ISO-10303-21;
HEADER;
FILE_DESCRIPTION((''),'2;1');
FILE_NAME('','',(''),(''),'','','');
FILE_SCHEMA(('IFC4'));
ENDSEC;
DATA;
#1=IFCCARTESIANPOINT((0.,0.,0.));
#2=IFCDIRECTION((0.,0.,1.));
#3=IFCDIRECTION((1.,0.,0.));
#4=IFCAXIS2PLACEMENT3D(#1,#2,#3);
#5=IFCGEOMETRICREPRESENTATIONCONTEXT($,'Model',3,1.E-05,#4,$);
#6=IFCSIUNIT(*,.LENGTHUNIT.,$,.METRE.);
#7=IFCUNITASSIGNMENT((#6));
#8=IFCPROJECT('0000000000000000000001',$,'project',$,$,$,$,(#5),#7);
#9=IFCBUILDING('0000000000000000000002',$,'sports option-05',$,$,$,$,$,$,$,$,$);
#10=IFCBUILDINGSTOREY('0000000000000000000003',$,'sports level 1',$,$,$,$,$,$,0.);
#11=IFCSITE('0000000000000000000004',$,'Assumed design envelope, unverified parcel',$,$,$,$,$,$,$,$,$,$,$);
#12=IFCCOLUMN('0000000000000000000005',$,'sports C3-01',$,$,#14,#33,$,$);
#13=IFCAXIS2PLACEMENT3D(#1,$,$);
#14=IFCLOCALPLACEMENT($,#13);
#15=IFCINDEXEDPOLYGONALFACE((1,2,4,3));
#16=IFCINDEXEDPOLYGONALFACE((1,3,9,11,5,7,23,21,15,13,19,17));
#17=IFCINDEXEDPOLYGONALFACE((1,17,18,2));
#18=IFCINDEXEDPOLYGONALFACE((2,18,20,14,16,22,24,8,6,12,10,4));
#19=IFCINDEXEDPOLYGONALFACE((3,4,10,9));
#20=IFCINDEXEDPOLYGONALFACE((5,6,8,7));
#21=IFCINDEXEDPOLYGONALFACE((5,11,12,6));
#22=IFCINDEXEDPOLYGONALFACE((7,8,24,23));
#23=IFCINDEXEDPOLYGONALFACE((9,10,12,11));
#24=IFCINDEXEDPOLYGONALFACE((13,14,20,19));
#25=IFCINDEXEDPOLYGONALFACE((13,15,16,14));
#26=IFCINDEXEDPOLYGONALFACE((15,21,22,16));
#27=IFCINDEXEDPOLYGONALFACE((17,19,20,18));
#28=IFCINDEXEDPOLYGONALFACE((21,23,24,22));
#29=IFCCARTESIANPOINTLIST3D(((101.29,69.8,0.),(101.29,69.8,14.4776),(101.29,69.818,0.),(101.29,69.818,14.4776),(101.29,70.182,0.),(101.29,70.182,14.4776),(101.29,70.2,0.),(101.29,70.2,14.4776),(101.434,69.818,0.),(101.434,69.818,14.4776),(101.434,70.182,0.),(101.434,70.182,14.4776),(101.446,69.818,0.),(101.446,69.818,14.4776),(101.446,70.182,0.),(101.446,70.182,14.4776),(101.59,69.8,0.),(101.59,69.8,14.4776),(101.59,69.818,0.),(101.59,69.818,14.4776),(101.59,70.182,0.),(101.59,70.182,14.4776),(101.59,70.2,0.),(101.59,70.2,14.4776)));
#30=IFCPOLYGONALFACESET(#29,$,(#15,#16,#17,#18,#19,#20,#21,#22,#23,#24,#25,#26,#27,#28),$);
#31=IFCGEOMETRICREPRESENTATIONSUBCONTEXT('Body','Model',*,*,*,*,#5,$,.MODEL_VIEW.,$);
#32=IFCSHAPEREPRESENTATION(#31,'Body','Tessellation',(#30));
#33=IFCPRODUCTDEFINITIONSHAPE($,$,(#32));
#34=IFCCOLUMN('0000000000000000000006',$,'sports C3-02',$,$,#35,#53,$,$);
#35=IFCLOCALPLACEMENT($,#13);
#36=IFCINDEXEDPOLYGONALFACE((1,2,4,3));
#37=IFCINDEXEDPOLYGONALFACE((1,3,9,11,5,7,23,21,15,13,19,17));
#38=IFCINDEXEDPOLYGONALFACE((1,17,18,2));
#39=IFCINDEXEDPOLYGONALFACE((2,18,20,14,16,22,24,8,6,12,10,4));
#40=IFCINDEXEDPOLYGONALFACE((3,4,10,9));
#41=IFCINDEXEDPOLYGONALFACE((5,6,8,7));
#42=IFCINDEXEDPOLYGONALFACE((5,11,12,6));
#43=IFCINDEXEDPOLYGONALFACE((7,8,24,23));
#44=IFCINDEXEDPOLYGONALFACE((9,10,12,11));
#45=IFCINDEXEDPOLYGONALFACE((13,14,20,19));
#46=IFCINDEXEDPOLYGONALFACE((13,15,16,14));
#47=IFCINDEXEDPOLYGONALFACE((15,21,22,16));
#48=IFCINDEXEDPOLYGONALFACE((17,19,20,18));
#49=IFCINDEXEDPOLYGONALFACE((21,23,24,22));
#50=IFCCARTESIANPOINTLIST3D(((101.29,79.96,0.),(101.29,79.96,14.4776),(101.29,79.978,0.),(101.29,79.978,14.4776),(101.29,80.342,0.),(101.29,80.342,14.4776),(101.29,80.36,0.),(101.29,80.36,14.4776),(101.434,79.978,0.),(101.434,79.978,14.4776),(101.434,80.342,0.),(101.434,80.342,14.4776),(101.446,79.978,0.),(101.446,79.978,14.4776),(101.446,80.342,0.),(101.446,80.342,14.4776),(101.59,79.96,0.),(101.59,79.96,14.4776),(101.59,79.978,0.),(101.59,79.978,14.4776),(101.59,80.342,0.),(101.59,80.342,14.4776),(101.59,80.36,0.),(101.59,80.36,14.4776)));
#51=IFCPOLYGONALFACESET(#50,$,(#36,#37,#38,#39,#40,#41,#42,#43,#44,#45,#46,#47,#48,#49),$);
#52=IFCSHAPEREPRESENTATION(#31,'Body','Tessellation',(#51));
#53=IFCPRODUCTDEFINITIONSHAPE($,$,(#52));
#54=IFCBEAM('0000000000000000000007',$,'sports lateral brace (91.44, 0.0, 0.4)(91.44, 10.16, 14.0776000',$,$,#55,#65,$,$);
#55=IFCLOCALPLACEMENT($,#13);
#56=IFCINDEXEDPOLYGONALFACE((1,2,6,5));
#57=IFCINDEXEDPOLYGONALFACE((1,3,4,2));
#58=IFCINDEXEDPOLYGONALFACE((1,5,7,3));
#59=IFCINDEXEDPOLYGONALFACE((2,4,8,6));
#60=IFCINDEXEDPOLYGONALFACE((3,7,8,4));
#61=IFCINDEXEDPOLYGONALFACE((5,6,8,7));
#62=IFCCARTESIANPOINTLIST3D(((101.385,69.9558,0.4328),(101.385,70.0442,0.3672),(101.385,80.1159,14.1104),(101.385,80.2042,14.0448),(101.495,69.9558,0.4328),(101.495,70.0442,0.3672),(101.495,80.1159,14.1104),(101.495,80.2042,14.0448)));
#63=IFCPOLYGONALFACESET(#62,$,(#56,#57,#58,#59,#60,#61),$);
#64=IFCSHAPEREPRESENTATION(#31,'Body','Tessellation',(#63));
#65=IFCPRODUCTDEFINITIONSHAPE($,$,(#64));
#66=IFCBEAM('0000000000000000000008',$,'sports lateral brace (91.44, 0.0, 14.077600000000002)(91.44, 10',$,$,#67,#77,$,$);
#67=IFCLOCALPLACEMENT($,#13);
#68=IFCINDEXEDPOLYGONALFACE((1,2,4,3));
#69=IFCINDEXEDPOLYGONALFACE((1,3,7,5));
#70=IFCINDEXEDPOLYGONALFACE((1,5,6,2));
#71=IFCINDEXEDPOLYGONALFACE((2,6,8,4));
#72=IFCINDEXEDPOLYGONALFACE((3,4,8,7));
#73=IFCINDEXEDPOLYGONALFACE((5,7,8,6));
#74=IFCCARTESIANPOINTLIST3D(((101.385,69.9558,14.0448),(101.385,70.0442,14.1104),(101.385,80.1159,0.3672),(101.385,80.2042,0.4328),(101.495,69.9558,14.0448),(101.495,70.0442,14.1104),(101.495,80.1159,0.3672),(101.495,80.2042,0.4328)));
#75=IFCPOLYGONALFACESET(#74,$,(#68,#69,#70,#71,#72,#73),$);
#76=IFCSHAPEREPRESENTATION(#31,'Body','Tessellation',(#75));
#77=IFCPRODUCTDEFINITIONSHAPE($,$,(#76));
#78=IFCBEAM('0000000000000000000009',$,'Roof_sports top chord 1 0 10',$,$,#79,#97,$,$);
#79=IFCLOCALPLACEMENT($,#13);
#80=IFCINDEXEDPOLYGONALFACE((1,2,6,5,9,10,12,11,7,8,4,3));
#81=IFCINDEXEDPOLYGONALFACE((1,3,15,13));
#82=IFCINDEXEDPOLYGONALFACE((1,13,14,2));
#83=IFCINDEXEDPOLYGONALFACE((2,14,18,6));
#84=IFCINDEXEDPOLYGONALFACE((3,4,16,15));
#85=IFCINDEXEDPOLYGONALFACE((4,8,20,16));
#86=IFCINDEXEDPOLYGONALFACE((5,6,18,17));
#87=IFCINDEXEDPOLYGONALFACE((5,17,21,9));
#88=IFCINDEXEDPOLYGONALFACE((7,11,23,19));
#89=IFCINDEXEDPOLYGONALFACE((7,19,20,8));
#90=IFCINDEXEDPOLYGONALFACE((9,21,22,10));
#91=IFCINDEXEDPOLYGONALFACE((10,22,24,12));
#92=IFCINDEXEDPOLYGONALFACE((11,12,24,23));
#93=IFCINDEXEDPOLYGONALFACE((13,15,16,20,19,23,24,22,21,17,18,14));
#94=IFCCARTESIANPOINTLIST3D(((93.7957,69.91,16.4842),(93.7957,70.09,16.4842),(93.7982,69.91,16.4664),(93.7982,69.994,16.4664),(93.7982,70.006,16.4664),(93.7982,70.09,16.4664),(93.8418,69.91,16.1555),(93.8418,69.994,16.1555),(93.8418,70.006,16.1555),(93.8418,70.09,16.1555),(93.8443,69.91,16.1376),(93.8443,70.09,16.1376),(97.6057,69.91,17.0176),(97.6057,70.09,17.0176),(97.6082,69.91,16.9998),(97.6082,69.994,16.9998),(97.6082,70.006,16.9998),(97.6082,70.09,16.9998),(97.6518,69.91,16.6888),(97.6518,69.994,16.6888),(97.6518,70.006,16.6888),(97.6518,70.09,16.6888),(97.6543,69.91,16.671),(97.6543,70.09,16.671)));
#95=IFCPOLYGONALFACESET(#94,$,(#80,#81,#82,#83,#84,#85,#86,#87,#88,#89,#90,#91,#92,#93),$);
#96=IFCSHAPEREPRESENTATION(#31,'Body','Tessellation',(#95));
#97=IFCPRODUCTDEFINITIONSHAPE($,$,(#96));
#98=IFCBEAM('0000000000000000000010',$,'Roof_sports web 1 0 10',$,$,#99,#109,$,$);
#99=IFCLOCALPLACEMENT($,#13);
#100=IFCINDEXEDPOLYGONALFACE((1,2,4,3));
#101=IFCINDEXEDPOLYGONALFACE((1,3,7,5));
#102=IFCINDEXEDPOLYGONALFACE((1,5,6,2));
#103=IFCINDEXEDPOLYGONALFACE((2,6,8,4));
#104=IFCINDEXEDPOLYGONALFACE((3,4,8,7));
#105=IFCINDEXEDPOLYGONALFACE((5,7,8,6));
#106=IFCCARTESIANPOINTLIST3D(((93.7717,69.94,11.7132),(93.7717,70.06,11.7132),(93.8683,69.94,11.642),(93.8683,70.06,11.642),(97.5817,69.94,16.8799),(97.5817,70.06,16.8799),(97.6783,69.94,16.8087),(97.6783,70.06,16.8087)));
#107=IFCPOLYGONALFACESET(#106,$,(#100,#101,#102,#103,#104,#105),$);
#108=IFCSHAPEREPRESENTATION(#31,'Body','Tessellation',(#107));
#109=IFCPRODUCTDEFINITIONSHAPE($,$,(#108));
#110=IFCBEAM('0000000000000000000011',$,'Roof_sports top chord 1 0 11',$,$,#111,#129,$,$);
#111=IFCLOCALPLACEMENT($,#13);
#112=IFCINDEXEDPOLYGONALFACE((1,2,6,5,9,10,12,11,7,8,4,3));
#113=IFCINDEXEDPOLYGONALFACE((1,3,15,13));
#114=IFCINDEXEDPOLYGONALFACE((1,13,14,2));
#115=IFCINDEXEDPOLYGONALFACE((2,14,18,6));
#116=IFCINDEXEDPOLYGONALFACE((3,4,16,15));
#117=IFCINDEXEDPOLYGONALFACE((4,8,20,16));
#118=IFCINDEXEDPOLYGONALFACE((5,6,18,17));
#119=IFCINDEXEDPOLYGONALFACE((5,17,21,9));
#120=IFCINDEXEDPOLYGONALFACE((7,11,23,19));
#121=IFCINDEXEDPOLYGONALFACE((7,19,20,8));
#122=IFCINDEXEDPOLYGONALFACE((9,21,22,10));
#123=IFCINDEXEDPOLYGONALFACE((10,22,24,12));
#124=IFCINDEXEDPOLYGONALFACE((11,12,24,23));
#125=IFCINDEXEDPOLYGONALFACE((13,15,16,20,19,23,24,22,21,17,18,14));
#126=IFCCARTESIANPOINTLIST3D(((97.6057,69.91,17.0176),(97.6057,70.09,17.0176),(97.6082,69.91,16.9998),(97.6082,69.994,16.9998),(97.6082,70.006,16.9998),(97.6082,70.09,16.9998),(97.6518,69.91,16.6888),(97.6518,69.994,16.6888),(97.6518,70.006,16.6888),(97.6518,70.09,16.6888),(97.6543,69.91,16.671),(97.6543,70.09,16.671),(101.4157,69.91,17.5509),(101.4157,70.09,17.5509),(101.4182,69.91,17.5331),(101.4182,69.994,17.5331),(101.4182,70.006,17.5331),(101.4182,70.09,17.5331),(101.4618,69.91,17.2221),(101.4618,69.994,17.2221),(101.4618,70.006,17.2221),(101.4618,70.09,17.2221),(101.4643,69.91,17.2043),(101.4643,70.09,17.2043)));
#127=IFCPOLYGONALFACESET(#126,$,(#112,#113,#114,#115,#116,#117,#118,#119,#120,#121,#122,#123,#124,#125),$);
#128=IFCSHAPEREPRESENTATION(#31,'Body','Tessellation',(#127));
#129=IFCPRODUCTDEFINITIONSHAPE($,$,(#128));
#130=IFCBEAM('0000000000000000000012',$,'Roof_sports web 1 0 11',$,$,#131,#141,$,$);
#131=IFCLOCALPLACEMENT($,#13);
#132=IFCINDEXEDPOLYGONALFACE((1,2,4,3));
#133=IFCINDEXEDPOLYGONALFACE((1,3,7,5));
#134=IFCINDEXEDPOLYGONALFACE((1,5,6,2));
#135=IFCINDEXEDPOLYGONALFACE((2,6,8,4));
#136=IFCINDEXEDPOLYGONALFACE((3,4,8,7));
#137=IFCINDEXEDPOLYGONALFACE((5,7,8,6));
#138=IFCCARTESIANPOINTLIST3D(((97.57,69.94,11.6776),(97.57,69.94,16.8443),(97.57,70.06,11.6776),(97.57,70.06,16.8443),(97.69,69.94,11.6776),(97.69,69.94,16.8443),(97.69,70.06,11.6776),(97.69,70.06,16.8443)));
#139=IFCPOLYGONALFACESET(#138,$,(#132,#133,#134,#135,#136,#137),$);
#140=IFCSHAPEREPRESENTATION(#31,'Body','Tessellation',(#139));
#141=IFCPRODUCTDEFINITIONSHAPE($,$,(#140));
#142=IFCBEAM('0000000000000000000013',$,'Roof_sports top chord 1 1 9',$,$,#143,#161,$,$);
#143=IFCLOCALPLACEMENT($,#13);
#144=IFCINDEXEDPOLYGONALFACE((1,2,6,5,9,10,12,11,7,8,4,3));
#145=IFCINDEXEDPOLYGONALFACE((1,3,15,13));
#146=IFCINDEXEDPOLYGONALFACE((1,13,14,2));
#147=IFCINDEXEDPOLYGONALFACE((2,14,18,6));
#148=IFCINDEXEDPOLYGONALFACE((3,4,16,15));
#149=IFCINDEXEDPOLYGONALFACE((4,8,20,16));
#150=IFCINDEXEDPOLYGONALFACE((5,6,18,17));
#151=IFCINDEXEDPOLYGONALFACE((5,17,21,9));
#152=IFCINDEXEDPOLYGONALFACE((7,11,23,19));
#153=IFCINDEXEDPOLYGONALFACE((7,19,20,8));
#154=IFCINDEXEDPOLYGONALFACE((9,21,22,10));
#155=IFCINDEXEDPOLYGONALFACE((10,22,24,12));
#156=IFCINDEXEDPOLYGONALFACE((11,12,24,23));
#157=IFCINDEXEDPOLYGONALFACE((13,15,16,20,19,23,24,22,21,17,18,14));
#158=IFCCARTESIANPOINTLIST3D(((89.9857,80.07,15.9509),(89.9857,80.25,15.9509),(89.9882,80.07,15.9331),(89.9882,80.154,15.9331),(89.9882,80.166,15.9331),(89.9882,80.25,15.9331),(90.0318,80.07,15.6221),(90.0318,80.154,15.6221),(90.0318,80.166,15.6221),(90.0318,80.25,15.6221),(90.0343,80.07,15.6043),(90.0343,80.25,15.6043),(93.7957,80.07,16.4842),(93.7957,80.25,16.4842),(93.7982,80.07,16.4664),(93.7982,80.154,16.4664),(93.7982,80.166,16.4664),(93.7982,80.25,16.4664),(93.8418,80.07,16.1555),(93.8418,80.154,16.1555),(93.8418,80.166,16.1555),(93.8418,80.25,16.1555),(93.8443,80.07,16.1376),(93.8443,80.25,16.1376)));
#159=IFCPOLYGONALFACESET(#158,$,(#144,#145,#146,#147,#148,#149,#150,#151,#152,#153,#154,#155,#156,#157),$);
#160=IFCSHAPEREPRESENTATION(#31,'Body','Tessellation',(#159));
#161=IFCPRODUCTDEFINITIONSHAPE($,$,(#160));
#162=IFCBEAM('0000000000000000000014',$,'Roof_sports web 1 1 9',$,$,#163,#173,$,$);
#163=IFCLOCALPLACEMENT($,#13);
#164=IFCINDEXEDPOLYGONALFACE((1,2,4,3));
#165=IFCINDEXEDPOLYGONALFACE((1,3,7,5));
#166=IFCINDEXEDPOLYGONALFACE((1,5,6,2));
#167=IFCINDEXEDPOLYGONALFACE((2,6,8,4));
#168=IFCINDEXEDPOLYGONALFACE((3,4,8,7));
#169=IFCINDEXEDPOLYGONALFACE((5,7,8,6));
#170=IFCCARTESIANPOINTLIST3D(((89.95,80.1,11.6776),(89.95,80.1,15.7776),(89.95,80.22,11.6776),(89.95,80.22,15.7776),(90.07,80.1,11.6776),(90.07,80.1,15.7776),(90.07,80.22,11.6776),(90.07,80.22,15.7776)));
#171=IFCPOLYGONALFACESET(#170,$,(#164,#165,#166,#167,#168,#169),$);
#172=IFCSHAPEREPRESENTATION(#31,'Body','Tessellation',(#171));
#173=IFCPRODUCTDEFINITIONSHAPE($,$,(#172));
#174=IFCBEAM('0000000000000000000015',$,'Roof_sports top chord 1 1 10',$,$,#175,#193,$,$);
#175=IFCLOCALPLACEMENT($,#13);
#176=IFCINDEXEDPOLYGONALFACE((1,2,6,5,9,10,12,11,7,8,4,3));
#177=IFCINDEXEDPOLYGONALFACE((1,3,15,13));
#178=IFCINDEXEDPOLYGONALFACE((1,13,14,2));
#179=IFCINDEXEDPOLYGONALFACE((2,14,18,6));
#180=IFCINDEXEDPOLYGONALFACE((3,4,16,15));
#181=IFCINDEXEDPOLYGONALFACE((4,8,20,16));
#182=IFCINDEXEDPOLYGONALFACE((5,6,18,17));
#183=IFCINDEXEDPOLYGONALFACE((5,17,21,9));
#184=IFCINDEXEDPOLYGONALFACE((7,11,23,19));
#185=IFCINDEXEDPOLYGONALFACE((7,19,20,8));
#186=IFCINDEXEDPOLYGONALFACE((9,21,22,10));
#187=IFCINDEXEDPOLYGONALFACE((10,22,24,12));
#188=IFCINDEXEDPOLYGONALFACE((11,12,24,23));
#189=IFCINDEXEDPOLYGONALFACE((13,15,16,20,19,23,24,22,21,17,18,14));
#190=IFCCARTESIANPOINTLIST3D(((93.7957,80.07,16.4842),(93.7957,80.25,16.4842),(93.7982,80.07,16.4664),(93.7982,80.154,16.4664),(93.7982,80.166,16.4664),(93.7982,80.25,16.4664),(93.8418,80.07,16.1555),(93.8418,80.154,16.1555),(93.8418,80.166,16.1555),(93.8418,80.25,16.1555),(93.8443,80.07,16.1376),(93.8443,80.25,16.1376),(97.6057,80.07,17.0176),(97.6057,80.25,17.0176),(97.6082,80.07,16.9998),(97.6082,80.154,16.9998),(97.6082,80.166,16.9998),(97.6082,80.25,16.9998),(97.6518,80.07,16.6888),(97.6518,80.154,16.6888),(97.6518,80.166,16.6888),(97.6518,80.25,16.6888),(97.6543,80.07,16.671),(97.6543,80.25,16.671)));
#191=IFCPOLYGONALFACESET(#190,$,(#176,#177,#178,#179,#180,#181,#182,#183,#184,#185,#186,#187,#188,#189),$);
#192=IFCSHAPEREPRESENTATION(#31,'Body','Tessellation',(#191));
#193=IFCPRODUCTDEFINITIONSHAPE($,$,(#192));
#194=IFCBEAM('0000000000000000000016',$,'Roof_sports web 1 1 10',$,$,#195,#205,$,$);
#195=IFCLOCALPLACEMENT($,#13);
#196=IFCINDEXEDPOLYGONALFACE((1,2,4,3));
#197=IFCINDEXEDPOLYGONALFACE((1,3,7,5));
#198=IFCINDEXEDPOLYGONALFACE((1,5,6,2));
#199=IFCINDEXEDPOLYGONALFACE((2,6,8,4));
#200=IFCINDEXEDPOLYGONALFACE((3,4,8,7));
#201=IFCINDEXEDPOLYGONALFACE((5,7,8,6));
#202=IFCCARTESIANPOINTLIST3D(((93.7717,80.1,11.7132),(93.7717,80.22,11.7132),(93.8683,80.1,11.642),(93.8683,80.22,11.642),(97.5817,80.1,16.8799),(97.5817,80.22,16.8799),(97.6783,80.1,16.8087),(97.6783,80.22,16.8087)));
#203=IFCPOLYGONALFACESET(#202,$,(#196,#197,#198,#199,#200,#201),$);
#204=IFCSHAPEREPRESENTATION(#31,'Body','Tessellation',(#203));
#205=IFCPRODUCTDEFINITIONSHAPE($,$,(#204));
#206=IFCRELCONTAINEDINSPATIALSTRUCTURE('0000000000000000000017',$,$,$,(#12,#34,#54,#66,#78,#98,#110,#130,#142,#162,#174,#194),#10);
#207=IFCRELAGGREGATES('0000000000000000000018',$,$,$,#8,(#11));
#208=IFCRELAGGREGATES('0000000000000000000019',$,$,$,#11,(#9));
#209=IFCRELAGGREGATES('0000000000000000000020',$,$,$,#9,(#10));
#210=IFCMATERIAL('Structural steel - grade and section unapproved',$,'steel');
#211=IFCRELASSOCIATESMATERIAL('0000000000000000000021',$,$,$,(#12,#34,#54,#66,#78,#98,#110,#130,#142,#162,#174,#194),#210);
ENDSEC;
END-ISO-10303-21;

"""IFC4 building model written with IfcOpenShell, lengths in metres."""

from ifc_helpers import new_model, si_unit, frame, origin_with_axes, place, context, subcontext, project, spatial, rectangle, i_section, extrude, material, element, save


model = new_model("IFC4")

# Units and contexts
model_context = context("Model", 3, precision=1e-05, world=origin_with_axes())
body_context = subcontext(model_context, "Body", "Model", "MODEL_VIEW")
ifc_project = project(units=[si_unit("LENGTHUNIT", "METRE")], contexts=[model_context])

# Site, building, storey
site = spatial("IfcSite", under=ifc_project, Name="Assumed design envelope, unverified parcel")
building = spatial("IfcBuilding", under=site, Name="sports option-05")
storey = spatial("IfcBuildingStorey", under=building, Name="sports level 1", Elevation=0.0)

# Columns
ifc_material_1 = material(Name="Structural steel - grade and section unapproved", Category="steel")
for number, where, z_axis, x_axis, name in (
    (1, (101.44, 70.0, 0.0), (0.0, 0.0, 1.0), (-1.0, 0.0, 0.0), "sports C3-01"),
    (2, (101.44, 80.16, 0.0), (0.0, 0.0, 1.0), (-1.0, 0.0, 0.0), "sports C3-02"),
):
    element("IfcColumn", number, at=place(None, frame(where, z_axis=z_axis, x_axis=x_axis)), inside=storey, material=ifc_material_1, Name=name, context=body_context, shape_type="SweptSolid", body=[
        extrude(i_section(OverallWidth=0.3, OverallDepth=0.4, WebThickness=0.012, FlangeThickness=0.018, FilletRadius=0.0), origin_with_axes(), (0.0, 0.0, 1.0), 14.4776),
    ])

# Beams
for number, where, z_axis, x_axis, name in (
    (3, (101.44, 70.0, 0.4), (0.0, 0.596305, 0.802758), (-1.0, 0.0, 0.0), "sports lateral brace (91.44, 0.0, 0.4)(91.44, 10.16, 14.0776000"),
    (4, (101.44, 70.0, 14.0776), (0.0, 0.596305, -0.802758), (-1.0, 0.0, 0.0), "sports lateral brace (91.44, 0.0, 14.077600000000002)(91.44, 10"),
):
    element("IfcBeam", number, at=place(None, frame(where, z_axis=z_axis, x_axis=x_axis)), inside=storey, material=ifc_material_1, Name=name, context=body_context, shape_type="SweptSolid", body=[
        extrude(rectangle(XDim=0.11, YDim=0.11), origin_with_axes(), (0.0, 0.0, 1.0), 17.0383),
    ])
beam_1_placement = place(None, frame((93.82, 70.0, 16.3109), z_axis=(0.990344, 0.0, 0.138631), x_axis=(0.0, 1.0, 0.0)))
element("IfcBeam", 5, at=beam_1_placement, inside=storey, material=ifc_material_1, Name="Roof_sports top chord 1 0 10", context=body_context, shape_type="SweptSolid", body=[
    extrude(i_section(OverallWidth=0.18, OverallDepth=0.35, WebThickness=0.012, FlangeThickness=0.018, FilletRadius=0.0), origin_with_axes(), (0.0, 0.0, 1.0), 3.8471),
])
beam_2_placement = place(None, frame((93.82, 70.0, 11.6776), z_axis=(0.5935, 0.0, 0.804834), x_axis=(0.0, 1.0, 0.0)))
element("IfcBeam", 6, at=beam_2_placement, inside=storey, material=ifc_material_1, Name="Roof_sports web 1 0 10", context=body_context, shape_type="SweptSolid", body=[
    extrude(rectangle(XDim=0.12, YDim=0.12), origin_with_axes(), (0.0, 0.0, 1.0), 6.4195),
])
beam_3_placement = place(None, frame((97.63, 70.0, 16.8443), z_axis=(0.990344, 0.0, 0.138631), x_axis=(0.0, 1.0, 0.0)))
element("IfcBeam", 7, at=beam_3_placement, inside=storey, material=ifc_material_1, Name="Roof_sports top chord 1 0 11", context=body_context, shape_type="SweptSolid", body=[
    extrude(i_section(OverallWidth=0.18, OverallDepth=0.35, WebThickness=0.012, FlangeThickness=0.018, FilletRadius=0.0), origin_with_axes(), (0.0, 0.0, 1.0), 3.8472),
])
beam_4_placement = place(None, frame((97.63, 70.0, 11.6776), z_axis=(0.0, 0.0, 1.0), x_axis=(-1.0, 0.0, 0.0)))
element("IfcBeam", 8, at=beam_4_placement, inside=storey, material=ifc_material_1, Name="Roof_sports web 1 0 11", context=body_context, shape_type="SweptSolid", body=[
    extrude(rectangle(XDim=0.12, YDim=0.12), origin_with_axes(), (0.0, 0.0, 1.0), 5.1667),
])
beam_5_placement = place(None, frame((90.01, 80.16, 15.7776), z_axis=(0.990344, 0.0, 0.138631), x_axis=(0.0, 1.0, 0.0)))
element("IfcBeam", 9, at=beam_5_placement, inside=storey, material=ifc_material_1, Name="Roof_sports top chord 1 1 9", context=body_context, shape_type="SweptSolid", body=[
    extrude(i_section(OverallWidth=0.18, OverallDepth=0.35, WebThickness=0.012, FlangeThickness=0.018, FilletRadius=0.0), origin_with_axes(), (0.0, 0.0, 1.0), 3.8471),
])
beam_6_placement = place(None, frame((90.01, 80.16, 11.6776), z_axis=(0.0, 0.0, 1.0), x_axis=(-1.0, 0.0, 0.0)))
element("IfcBeam", 10, at=beam_6_placement, inside=storey, material=ifc_material_1, Name="Roof_sports web 1 1 9", context=body_context, shape_type="SweptSolid", body=[
    extrude(rectangle(XDim=0.12, YDim=0.12), origin_with_axes(), (0.0, 0.0, 1.0), 4.1),
])
beam_7_placement = place(None, frame((93.82, 80.16, 16.3109), z_axis=(0.990344, 0.0, 0.138631), x_axis=(0.0, 1.0, 0.0)))
element("IfcBeam", 11, at=beam_7_placement, inside=storey, material=ifc_material_1, Name="Roof_sports top chord 1 1 10", context=body_context, shape_type="SweptSolid", body=[
    extrude(i_section(OverallWidth=0.18, OverallDepth=0.35, WebThickness=0.012, FlangeThickness=0.018, FilletRadius=0.0), origin_with_axes(), (0.0, 0.0, 1.0), 3.8471),
])
beam_8_placement = place(None, frame((93.82, 80.16, 11.6776), z_axis=(0.5935, 0.0, 0.804834), x_axis=(0.0, 1.0, 0.0)))
element("IfcBeam", 12, at=beam_8_placement, inside=storey, material=ifc_material_1, Name="Roof_sports web 1 1 10", context=body_context, shape_type="SweptSolid", body=[
    extrude(rectangle(XDim=0.12, YDim=0.12), origin_with_axes(), (0.0, 0.0, 1.0), 6.4195),
])

save(model, "model.ifc")
